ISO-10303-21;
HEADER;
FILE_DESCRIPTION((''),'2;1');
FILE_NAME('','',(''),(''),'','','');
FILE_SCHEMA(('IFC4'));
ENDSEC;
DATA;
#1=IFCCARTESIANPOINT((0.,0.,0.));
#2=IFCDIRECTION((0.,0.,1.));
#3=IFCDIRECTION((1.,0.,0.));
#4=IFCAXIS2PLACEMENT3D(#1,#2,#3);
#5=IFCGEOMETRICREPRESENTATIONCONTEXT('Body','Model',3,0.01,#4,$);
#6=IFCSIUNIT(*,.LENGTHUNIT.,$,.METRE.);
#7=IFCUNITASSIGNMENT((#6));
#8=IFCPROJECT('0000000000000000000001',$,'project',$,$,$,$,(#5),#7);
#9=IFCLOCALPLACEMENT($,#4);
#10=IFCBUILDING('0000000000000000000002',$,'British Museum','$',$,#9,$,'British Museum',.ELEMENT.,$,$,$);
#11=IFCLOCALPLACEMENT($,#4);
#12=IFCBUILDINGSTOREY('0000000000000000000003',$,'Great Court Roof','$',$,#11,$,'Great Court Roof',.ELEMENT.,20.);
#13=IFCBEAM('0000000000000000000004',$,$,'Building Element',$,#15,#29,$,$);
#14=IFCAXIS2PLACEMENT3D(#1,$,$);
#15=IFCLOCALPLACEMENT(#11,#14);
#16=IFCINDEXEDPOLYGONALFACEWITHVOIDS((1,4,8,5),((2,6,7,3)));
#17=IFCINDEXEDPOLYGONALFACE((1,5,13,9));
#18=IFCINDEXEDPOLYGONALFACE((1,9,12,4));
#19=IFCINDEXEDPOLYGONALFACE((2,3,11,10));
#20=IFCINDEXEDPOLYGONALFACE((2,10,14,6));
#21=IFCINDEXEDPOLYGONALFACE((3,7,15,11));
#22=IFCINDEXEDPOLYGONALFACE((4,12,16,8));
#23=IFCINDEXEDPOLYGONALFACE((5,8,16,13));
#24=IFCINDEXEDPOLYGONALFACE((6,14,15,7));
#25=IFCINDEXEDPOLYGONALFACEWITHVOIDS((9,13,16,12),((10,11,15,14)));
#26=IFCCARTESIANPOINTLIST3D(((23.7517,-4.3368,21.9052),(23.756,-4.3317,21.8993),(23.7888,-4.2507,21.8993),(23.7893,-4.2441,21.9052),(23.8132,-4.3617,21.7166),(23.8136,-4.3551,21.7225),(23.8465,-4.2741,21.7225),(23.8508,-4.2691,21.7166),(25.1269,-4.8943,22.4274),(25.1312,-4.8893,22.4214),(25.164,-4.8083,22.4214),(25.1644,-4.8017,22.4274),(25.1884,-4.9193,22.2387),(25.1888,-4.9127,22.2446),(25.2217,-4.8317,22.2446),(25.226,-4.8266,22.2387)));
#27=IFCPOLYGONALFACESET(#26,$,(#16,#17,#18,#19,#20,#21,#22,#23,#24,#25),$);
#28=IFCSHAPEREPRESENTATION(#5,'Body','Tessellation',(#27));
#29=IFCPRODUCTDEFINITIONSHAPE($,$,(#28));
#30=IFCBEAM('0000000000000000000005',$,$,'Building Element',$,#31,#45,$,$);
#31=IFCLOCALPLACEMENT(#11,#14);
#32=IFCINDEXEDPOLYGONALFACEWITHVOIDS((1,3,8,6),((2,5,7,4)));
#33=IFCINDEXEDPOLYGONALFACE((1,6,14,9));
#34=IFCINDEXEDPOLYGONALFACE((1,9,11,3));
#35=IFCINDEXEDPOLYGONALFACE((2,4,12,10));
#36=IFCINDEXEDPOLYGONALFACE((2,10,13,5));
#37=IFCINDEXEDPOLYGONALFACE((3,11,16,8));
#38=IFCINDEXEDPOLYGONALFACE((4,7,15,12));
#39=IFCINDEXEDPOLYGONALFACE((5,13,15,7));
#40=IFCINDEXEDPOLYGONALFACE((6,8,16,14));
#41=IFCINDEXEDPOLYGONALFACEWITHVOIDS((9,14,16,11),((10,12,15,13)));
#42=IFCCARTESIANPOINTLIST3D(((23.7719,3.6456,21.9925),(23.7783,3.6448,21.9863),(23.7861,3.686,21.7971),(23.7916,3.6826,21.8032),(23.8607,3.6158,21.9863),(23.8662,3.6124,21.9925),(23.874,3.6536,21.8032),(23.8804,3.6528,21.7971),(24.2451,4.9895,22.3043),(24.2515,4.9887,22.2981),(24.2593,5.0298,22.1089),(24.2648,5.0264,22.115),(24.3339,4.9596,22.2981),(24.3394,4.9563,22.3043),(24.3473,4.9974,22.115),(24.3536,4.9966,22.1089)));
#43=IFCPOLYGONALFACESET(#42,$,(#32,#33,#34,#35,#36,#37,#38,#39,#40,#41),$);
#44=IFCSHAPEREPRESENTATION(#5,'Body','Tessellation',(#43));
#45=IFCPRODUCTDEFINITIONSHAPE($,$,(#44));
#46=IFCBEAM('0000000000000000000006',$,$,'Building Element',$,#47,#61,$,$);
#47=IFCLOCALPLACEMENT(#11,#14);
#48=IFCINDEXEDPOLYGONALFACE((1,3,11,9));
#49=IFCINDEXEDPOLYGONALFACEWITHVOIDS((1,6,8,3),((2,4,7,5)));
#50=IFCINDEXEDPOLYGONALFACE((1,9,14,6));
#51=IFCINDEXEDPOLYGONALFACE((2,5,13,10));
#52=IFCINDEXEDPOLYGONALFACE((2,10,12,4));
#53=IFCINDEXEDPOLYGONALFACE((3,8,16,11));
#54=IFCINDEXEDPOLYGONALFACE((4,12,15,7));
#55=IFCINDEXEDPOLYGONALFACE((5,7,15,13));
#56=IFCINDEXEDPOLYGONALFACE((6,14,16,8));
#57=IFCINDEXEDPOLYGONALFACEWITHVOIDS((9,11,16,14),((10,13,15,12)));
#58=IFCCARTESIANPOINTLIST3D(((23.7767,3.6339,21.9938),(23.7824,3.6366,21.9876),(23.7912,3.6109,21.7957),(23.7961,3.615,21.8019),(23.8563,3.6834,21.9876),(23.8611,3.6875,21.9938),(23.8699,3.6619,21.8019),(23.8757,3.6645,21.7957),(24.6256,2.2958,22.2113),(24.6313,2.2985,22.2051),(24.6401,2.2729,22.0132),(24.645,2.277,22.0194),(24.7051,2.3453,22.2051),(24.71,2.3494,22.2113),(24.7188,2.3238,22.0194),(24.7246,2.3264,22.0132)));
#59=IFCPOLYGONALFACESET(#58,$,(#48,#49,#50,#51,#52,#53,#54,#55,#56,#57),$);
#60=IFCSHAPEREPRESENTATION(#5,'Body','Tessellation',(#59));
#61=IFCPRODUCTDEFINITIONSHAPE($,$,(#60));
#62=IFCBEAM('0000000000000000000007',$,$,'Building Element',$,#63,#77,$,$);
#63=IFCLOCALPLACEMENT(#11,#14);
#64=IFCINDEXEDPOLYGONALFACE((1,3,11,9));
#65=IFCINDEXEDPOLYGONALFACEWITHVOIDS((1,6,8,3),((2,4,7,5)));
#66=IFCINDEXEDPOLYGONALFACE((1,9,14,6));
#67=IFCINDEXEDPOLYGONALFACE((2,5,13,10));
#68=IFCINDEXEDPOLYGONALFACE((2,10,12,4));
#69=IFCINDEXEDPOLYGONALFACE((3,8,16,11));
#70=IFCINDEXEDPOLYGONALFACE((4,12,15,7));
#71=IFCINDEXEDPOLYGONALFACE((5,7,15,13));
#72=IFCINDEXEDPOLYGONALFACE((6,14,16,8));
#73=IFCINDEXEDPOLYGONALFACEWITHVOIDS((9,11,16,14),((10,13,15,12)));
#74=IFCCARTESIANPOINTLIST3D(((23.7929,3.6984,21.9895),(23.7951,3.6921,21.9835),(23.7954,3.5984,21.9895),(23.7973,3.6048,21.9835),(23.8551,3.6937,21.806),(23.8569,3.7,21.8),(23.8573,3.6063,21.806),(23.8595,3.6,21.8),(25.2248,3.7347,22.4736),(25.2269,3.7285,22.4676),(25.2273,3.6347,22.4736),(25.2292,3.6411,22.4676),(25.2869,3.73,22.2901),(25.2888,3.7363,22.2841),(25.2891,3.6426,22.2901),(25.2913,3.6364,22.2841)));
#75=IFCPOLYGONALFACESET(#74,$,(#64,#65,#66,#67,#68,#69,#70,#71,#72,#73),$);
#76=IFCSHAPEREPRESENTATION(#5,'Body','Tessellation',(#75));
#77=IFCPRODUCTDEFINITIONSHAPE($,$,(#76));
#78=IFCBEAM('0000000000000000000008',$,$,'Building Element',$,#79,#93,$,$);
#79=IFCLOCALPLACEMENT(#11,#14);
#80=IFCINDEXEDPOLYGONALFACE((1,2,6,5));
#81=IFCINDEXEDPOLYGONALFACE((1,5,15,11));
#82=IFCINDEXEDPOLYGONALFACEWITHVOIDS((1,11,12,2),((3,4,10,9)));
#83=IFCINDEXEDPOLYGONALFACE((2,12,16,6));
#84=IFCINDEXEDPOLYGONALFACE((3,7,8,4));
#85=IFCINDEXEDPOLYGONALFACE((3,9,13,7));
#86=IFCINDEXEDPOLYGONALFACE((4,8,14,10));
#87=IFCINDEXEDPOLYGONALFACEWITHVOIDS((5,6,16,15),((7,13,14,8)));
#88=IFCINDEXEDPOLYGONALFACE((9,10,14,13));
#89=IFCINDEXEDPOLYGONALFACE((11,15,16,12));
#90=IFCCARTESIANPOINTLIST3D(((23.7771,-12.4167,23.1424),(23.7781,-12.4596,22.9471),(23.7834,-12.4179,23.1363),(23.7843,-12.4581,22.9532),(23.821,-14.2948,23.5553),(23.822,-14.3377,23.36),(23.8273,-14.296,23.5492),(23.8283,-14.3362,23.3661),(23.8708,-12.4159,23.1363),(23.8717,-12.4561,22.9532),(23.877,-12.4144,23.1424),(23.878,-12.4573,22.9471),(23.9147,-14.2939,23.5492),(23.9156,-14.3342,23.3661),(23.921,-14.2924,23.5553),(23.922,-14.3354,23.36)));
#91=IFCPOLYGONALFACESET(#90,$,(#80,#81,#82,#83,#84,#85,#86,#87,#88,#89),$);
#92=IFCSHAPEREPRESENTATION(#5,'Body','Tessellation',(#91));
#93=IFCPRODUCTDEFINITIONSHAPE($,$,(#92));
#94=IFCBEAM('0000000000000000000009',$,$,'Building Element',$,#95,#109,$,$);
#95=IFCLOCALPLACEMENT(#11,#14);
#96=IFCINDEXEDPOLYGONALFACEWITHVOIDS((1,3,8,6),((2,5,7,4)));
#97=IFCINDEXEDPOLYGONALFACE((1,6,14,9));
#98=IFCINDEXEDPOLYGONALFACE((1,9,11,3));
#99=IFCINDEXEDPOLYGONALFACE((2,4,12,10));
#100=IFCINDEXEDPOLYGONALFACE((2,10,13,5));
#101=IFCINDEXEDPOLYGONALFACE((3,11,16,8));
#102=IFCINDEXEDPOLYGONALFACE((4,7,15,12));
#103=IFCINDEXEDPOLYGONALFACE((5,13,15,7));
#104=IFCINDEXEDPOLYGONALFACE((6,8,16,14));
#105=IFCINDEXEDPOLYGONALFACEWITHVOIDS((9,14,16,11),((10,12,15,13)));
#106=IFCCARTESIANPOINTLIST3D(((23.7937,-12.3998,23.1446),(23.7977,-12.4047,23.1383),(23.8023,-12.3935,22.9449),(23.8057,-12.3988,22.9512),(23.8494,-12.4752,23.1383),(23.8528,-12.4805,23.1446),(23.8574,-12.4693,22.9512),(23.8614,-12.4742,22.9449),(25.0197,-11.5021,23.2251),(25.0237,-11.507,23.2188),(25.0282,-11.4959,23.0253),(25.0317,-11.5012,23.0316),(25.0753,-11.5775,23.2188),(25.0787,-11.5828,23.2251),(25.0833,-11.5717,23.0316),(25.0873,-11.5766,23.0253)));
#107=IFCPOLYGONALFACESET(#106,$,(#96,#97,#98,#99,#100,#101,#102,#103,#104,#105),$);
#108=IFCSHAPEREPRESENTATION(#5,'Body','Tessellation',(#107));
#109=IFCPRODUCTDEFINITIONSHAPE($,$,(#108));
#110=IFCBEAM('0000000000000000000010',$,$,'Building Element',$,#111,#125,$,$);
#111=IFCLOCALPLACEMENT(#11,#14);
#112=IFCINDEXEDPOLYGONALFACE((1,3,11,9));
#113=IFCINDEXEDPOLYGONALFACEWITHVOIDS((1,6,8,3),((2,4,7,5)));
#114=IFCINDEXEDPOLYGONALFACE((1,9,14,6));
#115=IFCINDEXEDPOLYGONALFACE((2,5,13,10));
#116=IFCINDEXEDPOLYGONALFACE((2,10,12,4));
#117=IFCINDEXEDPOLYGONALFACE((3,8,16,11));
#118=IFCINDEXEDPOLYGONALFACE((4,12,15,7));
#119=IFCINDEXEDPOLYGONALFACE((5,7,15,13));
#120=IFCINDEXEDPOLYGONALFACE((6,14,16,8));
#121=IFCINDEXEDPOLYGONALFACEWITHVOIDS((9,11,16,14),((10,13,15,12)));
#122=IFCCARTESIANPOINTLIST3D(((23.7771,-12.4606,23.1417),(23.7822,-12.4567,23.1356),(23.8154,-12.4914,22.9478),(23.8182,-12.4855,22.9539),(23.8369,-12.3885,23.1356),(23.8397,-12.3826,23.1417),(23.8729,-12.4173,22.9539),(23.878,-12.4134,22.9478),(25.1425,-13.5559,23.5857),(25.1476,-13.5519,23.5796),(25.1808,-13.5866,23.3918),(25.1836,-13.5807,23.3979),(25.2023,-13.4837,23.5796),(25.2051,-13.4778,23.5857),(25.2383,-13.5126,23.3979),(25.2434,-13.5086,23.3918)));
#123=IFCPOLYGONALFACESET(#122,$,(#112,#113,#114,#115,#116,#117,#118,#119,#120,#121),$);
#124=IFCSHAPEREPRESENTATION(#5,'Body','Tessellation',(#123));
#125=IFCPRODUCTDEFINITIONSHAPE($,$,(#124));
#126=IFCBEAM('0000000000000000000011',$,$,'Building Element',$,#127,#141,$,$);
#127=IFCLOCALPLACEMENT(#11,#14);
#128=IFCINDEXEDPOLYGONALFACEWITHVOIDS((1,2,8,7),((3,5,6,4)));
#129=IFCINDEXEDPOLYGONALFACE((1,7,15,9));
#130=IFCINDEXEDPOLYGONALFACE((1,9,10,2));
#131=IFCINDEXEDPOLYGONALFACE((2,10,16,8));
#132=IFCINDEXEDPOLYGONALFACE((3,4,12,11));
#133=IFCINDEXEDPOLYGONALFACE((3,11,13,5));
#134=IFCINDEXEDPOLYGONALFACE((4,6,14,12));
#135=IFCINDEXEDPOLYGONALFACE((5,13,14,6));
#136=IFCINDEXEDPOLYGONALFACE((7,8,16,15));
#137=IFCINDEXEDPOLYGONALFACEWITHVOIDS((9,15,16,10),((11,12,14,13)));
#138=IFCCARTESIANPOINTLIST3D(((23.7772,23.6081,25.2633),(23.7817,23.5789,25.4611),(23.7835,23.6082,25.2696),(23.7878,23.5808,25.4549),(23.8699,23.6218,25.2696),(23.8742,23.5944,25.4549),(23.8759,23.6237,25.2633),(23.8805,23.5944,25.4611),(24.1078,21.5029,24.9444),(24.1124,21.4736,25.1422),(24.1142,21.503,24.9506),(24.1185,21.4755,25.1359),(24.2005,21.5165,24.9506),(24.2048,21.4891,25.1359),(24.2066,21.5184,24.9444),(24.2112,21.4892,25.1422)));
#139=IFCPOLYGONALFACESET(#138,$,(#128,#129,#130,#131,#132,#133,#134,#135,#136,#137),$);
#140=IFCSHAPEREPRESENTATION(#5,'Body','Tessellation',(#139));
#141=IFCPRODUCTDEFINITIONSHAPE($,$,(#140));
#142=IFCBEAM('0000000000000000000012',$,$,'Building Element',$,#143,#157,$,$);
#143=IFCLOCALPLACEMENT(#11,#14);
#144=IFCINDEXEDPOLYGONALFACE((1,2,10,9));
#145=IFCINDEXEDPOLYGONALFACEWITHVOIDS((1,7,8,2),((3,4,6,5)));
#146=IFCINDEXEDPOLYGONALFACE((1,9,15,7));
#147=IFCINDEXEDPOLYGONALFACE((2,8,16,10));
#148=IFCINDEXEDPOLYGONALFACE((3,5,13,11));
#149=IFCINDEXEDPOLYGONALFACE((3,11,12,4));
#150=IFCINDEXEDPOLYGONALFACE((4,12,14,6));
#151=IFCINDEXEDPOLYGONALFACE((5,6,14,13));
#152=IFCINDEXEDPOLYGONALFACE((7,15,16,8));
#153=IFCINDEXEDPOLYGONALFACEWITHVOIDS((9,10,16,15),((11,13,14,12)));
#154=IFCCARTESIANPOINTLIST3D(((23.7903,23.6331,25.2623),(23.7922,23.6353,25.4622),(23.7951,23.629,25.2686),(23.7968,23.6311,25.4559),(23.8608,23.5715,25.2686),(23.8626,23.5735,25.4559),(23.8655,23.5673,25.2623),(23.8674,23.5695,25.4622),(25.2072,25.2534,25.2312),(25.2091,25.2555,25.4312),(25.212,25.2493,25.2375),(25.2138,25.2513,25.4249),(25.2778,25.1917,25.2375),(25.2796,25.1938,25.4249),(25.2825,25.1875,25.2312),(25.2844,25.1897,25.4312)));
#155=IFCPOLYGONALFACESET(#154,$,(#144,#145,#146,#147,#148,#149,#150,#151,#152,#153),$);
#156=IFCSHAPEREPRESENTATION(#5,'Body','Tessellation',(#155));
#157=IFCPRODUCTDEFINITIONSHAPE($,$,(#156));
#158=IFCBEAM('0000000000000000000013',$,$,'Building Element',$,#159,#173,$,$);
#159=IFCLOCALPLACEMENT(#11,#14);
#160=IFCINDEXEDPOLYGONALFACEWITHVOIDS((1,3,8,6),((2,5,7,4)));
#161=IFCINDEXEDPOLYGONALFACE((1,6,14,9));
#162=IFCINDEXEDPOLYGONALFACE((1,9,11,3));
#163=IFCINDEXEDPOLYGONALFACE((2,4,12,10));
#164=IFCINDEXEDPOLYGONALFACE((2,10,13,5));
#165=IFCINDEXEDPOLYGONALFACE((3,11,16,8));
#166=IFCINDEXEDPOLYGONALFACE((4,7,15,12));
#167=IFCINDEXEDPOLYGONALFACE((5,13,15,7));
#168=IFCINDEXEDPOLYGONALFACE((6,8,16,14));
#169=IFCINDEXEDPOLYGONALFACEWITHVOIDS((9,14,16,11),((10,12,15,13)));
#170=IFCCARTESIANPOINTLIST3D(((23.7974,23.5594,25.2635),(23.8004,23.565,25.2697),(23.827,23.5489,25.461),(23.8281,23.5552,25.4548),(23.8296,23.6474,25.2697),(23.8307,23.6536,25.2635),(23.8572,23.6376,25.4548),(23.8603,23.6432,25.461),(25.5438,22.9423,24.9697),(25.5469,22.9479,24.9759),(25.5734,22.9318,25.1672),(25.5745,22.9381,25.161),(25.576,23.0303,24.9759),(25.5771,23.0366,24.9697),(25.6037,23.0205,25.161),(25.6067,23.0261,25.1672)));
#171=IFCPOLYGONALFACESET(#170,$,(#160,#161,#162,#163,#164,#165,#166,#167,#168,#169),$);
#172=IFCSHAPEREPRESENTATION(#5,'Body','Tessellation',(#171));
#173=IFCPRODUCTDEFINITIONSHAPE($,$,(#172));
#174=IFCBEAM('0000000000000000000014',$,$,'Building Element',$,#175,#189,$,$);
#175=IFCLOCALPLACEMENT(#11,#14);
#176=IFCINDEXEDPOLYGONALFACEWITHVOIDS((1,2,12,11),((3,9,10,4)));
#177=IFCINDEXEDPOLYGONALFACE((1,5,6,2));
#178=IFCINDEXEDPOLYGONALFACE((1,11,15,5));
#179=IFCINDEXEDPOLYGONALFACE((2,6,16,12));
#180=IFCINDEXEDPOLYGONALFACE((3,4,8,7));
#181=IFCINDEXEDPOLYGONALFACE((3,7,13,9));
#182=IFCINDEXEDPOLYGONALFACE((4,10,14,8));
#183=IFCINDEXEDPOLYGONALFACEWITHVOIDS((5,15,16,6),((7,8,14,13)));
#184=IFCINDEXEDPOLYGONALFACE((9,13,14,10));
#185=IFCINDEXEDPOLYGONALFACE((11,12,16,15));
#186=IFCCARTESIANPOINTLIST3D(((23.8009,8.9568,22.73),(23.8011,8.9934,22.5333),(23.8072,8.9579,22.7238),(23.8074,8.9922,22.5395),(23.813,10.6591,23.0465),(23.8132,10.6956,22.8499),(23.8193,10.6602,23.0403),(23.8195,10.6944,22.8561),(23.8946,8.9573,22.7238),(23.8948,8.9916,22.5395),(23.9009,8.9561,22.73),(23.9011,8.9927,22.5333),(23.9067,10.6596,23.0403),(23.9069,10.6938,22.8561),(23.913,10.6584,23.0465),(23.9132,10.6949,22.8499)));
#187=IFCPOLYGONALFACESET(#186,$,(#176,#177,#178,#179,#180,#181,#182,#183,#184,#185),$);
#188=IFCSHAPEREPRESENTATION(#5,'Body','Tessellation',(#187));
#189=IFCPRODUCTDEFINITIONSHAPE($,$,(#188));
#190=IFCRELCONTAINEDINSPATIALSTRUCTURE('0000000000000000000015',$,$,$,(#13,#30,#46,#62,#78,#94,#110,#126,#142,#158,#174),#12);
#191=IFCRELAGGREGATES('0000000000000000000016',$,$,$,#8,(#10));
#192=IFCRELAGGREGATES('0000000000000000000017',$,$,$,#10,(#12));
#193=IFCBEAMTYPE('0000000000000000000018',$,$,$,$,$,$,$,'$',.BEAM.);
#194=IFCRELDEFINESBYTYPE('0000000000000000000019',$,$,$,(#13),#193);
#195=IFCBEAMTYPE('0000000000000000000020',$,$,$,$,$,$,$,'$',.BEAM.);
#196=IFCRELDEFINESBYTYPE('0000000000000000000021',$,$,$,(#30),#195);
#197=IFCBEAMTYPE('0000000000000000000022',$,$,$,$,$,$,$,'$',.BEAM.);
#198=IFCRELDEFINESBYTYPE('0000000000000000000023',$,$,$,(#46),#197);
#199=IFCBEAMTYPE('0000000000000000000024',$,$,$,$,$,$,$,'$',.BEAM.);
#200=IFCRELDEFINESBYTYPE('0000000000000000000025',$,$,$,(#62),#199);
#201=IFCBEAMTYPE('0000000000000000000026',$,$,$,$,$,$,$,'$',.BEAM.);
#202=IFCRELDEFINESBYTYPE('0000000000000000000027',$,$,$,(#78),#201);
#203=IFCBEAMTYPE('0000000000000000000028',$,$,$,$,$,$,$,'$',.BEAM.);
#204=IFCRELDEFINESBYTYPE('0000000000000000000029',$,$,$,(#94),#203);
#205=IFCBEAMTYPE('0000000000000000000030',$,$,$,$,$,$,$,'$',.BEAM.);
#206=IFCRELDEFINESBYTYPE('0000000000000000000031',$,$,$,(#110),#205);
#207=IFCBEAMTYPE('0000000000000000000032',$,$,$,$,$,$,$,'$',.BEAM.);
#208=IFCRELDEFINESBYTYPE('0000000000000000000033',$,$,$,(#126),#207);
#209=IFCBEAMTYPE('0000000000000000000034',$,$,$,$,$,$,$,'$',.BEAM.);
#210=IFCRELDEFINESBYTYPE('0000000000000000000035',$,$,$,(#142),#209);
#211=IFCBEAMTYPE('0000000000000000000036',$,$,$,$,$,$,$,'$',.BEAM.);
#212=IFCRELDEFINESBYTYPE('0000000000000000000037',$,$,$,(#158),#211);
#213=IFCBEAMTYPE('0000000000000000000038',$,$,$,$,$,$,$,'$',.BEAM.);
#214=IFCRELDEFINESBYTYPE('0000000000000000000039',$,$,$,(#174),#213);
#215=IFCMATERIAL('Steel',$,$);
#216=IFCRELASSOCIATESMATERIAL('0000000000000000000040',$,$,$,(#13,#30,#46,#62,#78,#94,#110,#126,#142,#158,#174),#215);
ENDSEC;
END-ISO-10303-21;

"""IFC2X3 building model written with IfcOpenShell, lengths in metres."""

from ifc_helpers import new_model, si_unit, frame, origin_with_axes, origin_2d, place, context, project, spatial, hollow_rectangle, extrude, material, type_object, element, save


model = new_model("IFC2X3")

# Units and contexts
model_context = context("Model", 3, precision=0.01, world=origin_with_axes(), identifier="Body")
ifc_project = project(units=[si_unit("LENGTHUNIT", "METRE")], contexts=[model_context])

# Building, storey
building_placement = place(None, origin_with_axes())
building = spatial("IfcBuilding", under=ifc_project, at=building_placement, Name="British Museum", Description="$", LongName="British Museum", CompositionType="ELEMENT")
storey_placement = place(None, origin_with_axes())
storey = spatial("IfcBuildingStorey", under=building, at=storey_placement, Name="Great Court Roof", Description="$", LongName="Great Court Roof", CompositionType="ELEMENT", Elevation=20.0)

# Beams
ifc_material = material(Name="Steel")
beam_type_1 = type_object("IfcBeamType", ElementType="$", PredefinedType="BEAM")
beam_1_placement = place(None, origin_with_axes())
element("IfcBeam", 1, at=beam_1_placement, inside=storey, type_object=beam_type_1, material=ifc_material, Description="Building Element", context=model_context, shape_type="SweptSolid", body=[
    extrude(hollow_rectangle(XDim=0.1, YDim=0.2, WallThickness=0.0063, InnerFilletRadius=-0.0063, OuterFilletRadius=0.0, at=origin_2d()), frame((23.8012, -4.3029, 21.8109), z_axis=(0.874188, -0.354433, 0.331921), x_axis=(0.375735, 0.926727, 0.0)), (0.0, 0.0, 1.0), 1.5731),
])
beam_type_2 = type_object("IfcBeamType", ElementType="$", PredefinedType="BEAM")
beam_2_placement = place(None, origin_with_axes())
element("IfcBeam", 2, at=beam_2_placement, inside=storey, type_object=beam_type_2, material=ifc_material, Description="Building Element", context=model_context, shape_type="SweptSolid", body=[
    extrude(hollow_rectangle(XDim=0.1, YDim=0.2, WallThickness=0.0063, InnerFilletRadius=-0.0063, OuterFilletRadius=0.0, at=origin_2d()), frame((23.8262, 3.6492, 21.8948), z_axis=(0.324463, 0.921422, 0.213786), x_axis=(-0.943229, 0.332142, 0.0)), (0.0, 0.0, 1.0), 1.4584),
])
beam_type_3 = type_object("IfcBeamType", ElementType="$", PredefinedType="BEAM")
beam_3_placement = place(None, origin_with_axes())
element("IfcBeam", 3, at=beam_3_placement, inside=storey, type_object=beam_type_3, material=ifc_material, Description="Building Element", context=model_context, shape_type="SweptSolid", body=[
    extrude(hollow_rectangle(XDim=0.1, YDim=0.2, WallThickness=0.0063, InnerFilletRadius=-0.0063, OuterFilletRadius=0.0, at=origin_2d()), frame((23.8262, 3.6492, 21.8948), z_axis=(0.53072, -0.836571, 0.135962), x_axis=(0.844412, 0.535694, 0.0)), (0.0, 0.0, 1.0), 1.5995),
])
beam_type_4 = type_object("IfcBeamType", ElementType="$", PredefinedType="BEAM")
beam_4_placement = place(None, origin_with_axes())
element("IfcBeam", 4, at=beam_4_placement, inside=storey, type_object=beam_type_4, material=ifc_material, Description="Building Element", context=model_context, shape_type="SweptSolid", body=[
    extrude(hollow_rectangle(XDim=0.1, YDim=0.2, WallThickness=0.0063, InnerFilletRadius=-0.0063, OuterFilletRadius=0.0, at=origin_2d()), frame((23.8262, 3.6492, 21.8948), z_axis=(0.94705, 0.024024, 0.320186), x_axis=(-0.025359, 0.999678, 0.0)), (0.0, 0.0, 1.0), 1.5119),
])
beam_type_5 = type_object("IfcBeamType", ElementType="$", PredefinedType="BEAM")
beam_5_placement = place(None, origin_with_axes())
element("IfcBeam", 5, at=beam_5_placement, inside=storey, type_object=beam_type_5, material=ifc_material, Description="Building Element", context=model_context, shape_type="SweptSolid", body=[
    extrude(hollow_rectangle(XDim=0.1, YDim=0.2, WallThickness=0.0063, InnerFilletRadius=-0.0063, OuterFilletRadius=0.0, at=origin_2d()), frame((23.8276, -12.437, 23.0447), z_axis=(0.022835, -0.97642, 0.214667), x_axis=(0.999727, 0.02338, 0.0)), (0.0, 0.0, 1.0), 1.9234),
])
beam_type_6 = type_object("IfcBeamType", ElementType="$", PredefinedType="BEAM")
beam_6_placement = place(None, origin_with_axes())
element("IfcBeam", 6, at=beam_6_placement, inside=storey, type_object=beam_type_6, material=ifc_material, Description="Building Element", context=model_context, shape_type="SweptSolid", body=[
    extrude(hollow_rectangle(XDim=0.1, YDim=0.2, WallThickness=0.0063, InnerFilletRadius=-0.0063, OuterFilletRadius=0.0, at=origin_2d()), frame((23.8276, -12.437, 23.0447), z_axis=(0.805705, 0.589953, 0.052875), x_axis=(-0.590779, 0.806833, 0.0)), (0.0, 0.0, 1.0), 1.5215),
])
beam_type_7 = type_object("IfcBeamType", ElementType="$", PredefinedType="BEAM")
beam_7_placement = place(None, origin_with_axes())
element("IfcBeam", 7, at=beam_7_placement, inside=storey, type_object=beam_type_7, material=ifc_material, Description="Building Element", context=model_context, shape_type="SweptSolid", body=[
    extrude(hollow_rectangle(XDim=0.1, YDim=0.2, WallThickness=0.0063, InnerFilletRadius=-0.0063, OuterFilletRadius=0.0, at=origin_2d()), frame((23.8276, -12.437, 23.0447), z_axis=(0.756103, -0.606508, 0.245877), x_axis=(0.625717, 0.78005, 0.0)), (0.0, 0.0, 1.0), 1.8058),
])
beam_type_8 = type_object("IfcBeamType", ElementType="$", PredefinedType="BEAM")
beam_8_placement = place(None, origin_with_axes())
element("IfcBeam", 8, at=beam_8_placement, inside=storey, type_object=beam_type_8, material=ifc_material, Description="Building Element", context=model_context, shape_type="SweptSolid", body=[
    extrude(hollow_rectangle(XDim=0.1, YDim=0.2, WallThickness=0.0063, InnerFilletRadius=-0.0063, OuterFilletRadius=0.0, at=origin_2d()), frame((23.8288, 23.6013, 25.3622), z_axis=(0.153456, -0.977005, -0.148029), x_axis=(0.987889, 0.155165, 0.0)), (0.0, 0.0, 1.0), 2.1548),
])
beam_type_9 = type_object("IfcBeamType", ElementType="$", PredefinedType="BEAM")
beam_9_placement = place(None, origin_with_axes())
element("IfcBeam", 9, at=beam_9_placement, inside=storey, type_object=beam_type_9, material=ifc_material, Description="Building Element", context=model_context, shape_type="SweptSolid", body=[
    extrude(hollow_rectangle(XDim=0.1, YDim=0.2, WallThickness=0.0063, InnerFilletRadius=-0.0063, OuterFilletRadius=0.0, at=origin_2d()), frame((23.8288, 23.6013, 25.3622), z_axis=(0.658245, 0.752665, -0.014436), x_axis=(-0.752744, 0.658314, 0.0)), (0.0, 0.0, 1.0), 2.1527),
])
beam_type_10 = type_object("IfcBeamType", ElementType="$", PredefinedType="BEAM")
beam_10_placement = place(None, origin_with_axes())
element("IfcBeam", 10, at=beam_10_placement, inside=storey, type_object=beam_type_10, material=ifc_material, Description="Building Element", context=model_context, shape_type="SweptSolid", body=[
    extrude(hollow_rectangle(XDim=0.1, YDim=0.2, WallThickness=0.0063, InnerFilletRadius=-0.0063, OuterFilletRadius=0.0, at=origin_2d()), frame((23.8288, 23.6013, 25.3622), z_axis=(0.93123, -0.329048, -0.156645), x_axis=(0.333161, 0.94287, 0.0)), (0.0, 0.0, 1.0), 1.8754),
])
beam_type_11 = type_object("IfcBeamType", ElementType="$", PredefinedType="BEAM")
beam_11_placement = place(None, origin_with_axes())
element("IfcBeam", 11, at=beam_11_placement, inside=storey, type_object=beam_type_11, material=ifc_material, Description="Building Element", context=model_context, shape_type="SweptSolid", body=[
    extrude(hollow_rectangle(XDim=0.1, YDim=0.2, WallThickness=0.0063, InnerFilletRadius=-0.0063, OuterFilletRadius=0.0, at=origin_2d()), frame((23.851, 8.9748, 22.6316), z_axis=(0.006991, 0.983119, 0.182836), x_axis=(-0.999975, 0.00711, 0.0)), (0.0, 0.0, 1.0), 1.7315),
])

save(model, "model.ifc")
